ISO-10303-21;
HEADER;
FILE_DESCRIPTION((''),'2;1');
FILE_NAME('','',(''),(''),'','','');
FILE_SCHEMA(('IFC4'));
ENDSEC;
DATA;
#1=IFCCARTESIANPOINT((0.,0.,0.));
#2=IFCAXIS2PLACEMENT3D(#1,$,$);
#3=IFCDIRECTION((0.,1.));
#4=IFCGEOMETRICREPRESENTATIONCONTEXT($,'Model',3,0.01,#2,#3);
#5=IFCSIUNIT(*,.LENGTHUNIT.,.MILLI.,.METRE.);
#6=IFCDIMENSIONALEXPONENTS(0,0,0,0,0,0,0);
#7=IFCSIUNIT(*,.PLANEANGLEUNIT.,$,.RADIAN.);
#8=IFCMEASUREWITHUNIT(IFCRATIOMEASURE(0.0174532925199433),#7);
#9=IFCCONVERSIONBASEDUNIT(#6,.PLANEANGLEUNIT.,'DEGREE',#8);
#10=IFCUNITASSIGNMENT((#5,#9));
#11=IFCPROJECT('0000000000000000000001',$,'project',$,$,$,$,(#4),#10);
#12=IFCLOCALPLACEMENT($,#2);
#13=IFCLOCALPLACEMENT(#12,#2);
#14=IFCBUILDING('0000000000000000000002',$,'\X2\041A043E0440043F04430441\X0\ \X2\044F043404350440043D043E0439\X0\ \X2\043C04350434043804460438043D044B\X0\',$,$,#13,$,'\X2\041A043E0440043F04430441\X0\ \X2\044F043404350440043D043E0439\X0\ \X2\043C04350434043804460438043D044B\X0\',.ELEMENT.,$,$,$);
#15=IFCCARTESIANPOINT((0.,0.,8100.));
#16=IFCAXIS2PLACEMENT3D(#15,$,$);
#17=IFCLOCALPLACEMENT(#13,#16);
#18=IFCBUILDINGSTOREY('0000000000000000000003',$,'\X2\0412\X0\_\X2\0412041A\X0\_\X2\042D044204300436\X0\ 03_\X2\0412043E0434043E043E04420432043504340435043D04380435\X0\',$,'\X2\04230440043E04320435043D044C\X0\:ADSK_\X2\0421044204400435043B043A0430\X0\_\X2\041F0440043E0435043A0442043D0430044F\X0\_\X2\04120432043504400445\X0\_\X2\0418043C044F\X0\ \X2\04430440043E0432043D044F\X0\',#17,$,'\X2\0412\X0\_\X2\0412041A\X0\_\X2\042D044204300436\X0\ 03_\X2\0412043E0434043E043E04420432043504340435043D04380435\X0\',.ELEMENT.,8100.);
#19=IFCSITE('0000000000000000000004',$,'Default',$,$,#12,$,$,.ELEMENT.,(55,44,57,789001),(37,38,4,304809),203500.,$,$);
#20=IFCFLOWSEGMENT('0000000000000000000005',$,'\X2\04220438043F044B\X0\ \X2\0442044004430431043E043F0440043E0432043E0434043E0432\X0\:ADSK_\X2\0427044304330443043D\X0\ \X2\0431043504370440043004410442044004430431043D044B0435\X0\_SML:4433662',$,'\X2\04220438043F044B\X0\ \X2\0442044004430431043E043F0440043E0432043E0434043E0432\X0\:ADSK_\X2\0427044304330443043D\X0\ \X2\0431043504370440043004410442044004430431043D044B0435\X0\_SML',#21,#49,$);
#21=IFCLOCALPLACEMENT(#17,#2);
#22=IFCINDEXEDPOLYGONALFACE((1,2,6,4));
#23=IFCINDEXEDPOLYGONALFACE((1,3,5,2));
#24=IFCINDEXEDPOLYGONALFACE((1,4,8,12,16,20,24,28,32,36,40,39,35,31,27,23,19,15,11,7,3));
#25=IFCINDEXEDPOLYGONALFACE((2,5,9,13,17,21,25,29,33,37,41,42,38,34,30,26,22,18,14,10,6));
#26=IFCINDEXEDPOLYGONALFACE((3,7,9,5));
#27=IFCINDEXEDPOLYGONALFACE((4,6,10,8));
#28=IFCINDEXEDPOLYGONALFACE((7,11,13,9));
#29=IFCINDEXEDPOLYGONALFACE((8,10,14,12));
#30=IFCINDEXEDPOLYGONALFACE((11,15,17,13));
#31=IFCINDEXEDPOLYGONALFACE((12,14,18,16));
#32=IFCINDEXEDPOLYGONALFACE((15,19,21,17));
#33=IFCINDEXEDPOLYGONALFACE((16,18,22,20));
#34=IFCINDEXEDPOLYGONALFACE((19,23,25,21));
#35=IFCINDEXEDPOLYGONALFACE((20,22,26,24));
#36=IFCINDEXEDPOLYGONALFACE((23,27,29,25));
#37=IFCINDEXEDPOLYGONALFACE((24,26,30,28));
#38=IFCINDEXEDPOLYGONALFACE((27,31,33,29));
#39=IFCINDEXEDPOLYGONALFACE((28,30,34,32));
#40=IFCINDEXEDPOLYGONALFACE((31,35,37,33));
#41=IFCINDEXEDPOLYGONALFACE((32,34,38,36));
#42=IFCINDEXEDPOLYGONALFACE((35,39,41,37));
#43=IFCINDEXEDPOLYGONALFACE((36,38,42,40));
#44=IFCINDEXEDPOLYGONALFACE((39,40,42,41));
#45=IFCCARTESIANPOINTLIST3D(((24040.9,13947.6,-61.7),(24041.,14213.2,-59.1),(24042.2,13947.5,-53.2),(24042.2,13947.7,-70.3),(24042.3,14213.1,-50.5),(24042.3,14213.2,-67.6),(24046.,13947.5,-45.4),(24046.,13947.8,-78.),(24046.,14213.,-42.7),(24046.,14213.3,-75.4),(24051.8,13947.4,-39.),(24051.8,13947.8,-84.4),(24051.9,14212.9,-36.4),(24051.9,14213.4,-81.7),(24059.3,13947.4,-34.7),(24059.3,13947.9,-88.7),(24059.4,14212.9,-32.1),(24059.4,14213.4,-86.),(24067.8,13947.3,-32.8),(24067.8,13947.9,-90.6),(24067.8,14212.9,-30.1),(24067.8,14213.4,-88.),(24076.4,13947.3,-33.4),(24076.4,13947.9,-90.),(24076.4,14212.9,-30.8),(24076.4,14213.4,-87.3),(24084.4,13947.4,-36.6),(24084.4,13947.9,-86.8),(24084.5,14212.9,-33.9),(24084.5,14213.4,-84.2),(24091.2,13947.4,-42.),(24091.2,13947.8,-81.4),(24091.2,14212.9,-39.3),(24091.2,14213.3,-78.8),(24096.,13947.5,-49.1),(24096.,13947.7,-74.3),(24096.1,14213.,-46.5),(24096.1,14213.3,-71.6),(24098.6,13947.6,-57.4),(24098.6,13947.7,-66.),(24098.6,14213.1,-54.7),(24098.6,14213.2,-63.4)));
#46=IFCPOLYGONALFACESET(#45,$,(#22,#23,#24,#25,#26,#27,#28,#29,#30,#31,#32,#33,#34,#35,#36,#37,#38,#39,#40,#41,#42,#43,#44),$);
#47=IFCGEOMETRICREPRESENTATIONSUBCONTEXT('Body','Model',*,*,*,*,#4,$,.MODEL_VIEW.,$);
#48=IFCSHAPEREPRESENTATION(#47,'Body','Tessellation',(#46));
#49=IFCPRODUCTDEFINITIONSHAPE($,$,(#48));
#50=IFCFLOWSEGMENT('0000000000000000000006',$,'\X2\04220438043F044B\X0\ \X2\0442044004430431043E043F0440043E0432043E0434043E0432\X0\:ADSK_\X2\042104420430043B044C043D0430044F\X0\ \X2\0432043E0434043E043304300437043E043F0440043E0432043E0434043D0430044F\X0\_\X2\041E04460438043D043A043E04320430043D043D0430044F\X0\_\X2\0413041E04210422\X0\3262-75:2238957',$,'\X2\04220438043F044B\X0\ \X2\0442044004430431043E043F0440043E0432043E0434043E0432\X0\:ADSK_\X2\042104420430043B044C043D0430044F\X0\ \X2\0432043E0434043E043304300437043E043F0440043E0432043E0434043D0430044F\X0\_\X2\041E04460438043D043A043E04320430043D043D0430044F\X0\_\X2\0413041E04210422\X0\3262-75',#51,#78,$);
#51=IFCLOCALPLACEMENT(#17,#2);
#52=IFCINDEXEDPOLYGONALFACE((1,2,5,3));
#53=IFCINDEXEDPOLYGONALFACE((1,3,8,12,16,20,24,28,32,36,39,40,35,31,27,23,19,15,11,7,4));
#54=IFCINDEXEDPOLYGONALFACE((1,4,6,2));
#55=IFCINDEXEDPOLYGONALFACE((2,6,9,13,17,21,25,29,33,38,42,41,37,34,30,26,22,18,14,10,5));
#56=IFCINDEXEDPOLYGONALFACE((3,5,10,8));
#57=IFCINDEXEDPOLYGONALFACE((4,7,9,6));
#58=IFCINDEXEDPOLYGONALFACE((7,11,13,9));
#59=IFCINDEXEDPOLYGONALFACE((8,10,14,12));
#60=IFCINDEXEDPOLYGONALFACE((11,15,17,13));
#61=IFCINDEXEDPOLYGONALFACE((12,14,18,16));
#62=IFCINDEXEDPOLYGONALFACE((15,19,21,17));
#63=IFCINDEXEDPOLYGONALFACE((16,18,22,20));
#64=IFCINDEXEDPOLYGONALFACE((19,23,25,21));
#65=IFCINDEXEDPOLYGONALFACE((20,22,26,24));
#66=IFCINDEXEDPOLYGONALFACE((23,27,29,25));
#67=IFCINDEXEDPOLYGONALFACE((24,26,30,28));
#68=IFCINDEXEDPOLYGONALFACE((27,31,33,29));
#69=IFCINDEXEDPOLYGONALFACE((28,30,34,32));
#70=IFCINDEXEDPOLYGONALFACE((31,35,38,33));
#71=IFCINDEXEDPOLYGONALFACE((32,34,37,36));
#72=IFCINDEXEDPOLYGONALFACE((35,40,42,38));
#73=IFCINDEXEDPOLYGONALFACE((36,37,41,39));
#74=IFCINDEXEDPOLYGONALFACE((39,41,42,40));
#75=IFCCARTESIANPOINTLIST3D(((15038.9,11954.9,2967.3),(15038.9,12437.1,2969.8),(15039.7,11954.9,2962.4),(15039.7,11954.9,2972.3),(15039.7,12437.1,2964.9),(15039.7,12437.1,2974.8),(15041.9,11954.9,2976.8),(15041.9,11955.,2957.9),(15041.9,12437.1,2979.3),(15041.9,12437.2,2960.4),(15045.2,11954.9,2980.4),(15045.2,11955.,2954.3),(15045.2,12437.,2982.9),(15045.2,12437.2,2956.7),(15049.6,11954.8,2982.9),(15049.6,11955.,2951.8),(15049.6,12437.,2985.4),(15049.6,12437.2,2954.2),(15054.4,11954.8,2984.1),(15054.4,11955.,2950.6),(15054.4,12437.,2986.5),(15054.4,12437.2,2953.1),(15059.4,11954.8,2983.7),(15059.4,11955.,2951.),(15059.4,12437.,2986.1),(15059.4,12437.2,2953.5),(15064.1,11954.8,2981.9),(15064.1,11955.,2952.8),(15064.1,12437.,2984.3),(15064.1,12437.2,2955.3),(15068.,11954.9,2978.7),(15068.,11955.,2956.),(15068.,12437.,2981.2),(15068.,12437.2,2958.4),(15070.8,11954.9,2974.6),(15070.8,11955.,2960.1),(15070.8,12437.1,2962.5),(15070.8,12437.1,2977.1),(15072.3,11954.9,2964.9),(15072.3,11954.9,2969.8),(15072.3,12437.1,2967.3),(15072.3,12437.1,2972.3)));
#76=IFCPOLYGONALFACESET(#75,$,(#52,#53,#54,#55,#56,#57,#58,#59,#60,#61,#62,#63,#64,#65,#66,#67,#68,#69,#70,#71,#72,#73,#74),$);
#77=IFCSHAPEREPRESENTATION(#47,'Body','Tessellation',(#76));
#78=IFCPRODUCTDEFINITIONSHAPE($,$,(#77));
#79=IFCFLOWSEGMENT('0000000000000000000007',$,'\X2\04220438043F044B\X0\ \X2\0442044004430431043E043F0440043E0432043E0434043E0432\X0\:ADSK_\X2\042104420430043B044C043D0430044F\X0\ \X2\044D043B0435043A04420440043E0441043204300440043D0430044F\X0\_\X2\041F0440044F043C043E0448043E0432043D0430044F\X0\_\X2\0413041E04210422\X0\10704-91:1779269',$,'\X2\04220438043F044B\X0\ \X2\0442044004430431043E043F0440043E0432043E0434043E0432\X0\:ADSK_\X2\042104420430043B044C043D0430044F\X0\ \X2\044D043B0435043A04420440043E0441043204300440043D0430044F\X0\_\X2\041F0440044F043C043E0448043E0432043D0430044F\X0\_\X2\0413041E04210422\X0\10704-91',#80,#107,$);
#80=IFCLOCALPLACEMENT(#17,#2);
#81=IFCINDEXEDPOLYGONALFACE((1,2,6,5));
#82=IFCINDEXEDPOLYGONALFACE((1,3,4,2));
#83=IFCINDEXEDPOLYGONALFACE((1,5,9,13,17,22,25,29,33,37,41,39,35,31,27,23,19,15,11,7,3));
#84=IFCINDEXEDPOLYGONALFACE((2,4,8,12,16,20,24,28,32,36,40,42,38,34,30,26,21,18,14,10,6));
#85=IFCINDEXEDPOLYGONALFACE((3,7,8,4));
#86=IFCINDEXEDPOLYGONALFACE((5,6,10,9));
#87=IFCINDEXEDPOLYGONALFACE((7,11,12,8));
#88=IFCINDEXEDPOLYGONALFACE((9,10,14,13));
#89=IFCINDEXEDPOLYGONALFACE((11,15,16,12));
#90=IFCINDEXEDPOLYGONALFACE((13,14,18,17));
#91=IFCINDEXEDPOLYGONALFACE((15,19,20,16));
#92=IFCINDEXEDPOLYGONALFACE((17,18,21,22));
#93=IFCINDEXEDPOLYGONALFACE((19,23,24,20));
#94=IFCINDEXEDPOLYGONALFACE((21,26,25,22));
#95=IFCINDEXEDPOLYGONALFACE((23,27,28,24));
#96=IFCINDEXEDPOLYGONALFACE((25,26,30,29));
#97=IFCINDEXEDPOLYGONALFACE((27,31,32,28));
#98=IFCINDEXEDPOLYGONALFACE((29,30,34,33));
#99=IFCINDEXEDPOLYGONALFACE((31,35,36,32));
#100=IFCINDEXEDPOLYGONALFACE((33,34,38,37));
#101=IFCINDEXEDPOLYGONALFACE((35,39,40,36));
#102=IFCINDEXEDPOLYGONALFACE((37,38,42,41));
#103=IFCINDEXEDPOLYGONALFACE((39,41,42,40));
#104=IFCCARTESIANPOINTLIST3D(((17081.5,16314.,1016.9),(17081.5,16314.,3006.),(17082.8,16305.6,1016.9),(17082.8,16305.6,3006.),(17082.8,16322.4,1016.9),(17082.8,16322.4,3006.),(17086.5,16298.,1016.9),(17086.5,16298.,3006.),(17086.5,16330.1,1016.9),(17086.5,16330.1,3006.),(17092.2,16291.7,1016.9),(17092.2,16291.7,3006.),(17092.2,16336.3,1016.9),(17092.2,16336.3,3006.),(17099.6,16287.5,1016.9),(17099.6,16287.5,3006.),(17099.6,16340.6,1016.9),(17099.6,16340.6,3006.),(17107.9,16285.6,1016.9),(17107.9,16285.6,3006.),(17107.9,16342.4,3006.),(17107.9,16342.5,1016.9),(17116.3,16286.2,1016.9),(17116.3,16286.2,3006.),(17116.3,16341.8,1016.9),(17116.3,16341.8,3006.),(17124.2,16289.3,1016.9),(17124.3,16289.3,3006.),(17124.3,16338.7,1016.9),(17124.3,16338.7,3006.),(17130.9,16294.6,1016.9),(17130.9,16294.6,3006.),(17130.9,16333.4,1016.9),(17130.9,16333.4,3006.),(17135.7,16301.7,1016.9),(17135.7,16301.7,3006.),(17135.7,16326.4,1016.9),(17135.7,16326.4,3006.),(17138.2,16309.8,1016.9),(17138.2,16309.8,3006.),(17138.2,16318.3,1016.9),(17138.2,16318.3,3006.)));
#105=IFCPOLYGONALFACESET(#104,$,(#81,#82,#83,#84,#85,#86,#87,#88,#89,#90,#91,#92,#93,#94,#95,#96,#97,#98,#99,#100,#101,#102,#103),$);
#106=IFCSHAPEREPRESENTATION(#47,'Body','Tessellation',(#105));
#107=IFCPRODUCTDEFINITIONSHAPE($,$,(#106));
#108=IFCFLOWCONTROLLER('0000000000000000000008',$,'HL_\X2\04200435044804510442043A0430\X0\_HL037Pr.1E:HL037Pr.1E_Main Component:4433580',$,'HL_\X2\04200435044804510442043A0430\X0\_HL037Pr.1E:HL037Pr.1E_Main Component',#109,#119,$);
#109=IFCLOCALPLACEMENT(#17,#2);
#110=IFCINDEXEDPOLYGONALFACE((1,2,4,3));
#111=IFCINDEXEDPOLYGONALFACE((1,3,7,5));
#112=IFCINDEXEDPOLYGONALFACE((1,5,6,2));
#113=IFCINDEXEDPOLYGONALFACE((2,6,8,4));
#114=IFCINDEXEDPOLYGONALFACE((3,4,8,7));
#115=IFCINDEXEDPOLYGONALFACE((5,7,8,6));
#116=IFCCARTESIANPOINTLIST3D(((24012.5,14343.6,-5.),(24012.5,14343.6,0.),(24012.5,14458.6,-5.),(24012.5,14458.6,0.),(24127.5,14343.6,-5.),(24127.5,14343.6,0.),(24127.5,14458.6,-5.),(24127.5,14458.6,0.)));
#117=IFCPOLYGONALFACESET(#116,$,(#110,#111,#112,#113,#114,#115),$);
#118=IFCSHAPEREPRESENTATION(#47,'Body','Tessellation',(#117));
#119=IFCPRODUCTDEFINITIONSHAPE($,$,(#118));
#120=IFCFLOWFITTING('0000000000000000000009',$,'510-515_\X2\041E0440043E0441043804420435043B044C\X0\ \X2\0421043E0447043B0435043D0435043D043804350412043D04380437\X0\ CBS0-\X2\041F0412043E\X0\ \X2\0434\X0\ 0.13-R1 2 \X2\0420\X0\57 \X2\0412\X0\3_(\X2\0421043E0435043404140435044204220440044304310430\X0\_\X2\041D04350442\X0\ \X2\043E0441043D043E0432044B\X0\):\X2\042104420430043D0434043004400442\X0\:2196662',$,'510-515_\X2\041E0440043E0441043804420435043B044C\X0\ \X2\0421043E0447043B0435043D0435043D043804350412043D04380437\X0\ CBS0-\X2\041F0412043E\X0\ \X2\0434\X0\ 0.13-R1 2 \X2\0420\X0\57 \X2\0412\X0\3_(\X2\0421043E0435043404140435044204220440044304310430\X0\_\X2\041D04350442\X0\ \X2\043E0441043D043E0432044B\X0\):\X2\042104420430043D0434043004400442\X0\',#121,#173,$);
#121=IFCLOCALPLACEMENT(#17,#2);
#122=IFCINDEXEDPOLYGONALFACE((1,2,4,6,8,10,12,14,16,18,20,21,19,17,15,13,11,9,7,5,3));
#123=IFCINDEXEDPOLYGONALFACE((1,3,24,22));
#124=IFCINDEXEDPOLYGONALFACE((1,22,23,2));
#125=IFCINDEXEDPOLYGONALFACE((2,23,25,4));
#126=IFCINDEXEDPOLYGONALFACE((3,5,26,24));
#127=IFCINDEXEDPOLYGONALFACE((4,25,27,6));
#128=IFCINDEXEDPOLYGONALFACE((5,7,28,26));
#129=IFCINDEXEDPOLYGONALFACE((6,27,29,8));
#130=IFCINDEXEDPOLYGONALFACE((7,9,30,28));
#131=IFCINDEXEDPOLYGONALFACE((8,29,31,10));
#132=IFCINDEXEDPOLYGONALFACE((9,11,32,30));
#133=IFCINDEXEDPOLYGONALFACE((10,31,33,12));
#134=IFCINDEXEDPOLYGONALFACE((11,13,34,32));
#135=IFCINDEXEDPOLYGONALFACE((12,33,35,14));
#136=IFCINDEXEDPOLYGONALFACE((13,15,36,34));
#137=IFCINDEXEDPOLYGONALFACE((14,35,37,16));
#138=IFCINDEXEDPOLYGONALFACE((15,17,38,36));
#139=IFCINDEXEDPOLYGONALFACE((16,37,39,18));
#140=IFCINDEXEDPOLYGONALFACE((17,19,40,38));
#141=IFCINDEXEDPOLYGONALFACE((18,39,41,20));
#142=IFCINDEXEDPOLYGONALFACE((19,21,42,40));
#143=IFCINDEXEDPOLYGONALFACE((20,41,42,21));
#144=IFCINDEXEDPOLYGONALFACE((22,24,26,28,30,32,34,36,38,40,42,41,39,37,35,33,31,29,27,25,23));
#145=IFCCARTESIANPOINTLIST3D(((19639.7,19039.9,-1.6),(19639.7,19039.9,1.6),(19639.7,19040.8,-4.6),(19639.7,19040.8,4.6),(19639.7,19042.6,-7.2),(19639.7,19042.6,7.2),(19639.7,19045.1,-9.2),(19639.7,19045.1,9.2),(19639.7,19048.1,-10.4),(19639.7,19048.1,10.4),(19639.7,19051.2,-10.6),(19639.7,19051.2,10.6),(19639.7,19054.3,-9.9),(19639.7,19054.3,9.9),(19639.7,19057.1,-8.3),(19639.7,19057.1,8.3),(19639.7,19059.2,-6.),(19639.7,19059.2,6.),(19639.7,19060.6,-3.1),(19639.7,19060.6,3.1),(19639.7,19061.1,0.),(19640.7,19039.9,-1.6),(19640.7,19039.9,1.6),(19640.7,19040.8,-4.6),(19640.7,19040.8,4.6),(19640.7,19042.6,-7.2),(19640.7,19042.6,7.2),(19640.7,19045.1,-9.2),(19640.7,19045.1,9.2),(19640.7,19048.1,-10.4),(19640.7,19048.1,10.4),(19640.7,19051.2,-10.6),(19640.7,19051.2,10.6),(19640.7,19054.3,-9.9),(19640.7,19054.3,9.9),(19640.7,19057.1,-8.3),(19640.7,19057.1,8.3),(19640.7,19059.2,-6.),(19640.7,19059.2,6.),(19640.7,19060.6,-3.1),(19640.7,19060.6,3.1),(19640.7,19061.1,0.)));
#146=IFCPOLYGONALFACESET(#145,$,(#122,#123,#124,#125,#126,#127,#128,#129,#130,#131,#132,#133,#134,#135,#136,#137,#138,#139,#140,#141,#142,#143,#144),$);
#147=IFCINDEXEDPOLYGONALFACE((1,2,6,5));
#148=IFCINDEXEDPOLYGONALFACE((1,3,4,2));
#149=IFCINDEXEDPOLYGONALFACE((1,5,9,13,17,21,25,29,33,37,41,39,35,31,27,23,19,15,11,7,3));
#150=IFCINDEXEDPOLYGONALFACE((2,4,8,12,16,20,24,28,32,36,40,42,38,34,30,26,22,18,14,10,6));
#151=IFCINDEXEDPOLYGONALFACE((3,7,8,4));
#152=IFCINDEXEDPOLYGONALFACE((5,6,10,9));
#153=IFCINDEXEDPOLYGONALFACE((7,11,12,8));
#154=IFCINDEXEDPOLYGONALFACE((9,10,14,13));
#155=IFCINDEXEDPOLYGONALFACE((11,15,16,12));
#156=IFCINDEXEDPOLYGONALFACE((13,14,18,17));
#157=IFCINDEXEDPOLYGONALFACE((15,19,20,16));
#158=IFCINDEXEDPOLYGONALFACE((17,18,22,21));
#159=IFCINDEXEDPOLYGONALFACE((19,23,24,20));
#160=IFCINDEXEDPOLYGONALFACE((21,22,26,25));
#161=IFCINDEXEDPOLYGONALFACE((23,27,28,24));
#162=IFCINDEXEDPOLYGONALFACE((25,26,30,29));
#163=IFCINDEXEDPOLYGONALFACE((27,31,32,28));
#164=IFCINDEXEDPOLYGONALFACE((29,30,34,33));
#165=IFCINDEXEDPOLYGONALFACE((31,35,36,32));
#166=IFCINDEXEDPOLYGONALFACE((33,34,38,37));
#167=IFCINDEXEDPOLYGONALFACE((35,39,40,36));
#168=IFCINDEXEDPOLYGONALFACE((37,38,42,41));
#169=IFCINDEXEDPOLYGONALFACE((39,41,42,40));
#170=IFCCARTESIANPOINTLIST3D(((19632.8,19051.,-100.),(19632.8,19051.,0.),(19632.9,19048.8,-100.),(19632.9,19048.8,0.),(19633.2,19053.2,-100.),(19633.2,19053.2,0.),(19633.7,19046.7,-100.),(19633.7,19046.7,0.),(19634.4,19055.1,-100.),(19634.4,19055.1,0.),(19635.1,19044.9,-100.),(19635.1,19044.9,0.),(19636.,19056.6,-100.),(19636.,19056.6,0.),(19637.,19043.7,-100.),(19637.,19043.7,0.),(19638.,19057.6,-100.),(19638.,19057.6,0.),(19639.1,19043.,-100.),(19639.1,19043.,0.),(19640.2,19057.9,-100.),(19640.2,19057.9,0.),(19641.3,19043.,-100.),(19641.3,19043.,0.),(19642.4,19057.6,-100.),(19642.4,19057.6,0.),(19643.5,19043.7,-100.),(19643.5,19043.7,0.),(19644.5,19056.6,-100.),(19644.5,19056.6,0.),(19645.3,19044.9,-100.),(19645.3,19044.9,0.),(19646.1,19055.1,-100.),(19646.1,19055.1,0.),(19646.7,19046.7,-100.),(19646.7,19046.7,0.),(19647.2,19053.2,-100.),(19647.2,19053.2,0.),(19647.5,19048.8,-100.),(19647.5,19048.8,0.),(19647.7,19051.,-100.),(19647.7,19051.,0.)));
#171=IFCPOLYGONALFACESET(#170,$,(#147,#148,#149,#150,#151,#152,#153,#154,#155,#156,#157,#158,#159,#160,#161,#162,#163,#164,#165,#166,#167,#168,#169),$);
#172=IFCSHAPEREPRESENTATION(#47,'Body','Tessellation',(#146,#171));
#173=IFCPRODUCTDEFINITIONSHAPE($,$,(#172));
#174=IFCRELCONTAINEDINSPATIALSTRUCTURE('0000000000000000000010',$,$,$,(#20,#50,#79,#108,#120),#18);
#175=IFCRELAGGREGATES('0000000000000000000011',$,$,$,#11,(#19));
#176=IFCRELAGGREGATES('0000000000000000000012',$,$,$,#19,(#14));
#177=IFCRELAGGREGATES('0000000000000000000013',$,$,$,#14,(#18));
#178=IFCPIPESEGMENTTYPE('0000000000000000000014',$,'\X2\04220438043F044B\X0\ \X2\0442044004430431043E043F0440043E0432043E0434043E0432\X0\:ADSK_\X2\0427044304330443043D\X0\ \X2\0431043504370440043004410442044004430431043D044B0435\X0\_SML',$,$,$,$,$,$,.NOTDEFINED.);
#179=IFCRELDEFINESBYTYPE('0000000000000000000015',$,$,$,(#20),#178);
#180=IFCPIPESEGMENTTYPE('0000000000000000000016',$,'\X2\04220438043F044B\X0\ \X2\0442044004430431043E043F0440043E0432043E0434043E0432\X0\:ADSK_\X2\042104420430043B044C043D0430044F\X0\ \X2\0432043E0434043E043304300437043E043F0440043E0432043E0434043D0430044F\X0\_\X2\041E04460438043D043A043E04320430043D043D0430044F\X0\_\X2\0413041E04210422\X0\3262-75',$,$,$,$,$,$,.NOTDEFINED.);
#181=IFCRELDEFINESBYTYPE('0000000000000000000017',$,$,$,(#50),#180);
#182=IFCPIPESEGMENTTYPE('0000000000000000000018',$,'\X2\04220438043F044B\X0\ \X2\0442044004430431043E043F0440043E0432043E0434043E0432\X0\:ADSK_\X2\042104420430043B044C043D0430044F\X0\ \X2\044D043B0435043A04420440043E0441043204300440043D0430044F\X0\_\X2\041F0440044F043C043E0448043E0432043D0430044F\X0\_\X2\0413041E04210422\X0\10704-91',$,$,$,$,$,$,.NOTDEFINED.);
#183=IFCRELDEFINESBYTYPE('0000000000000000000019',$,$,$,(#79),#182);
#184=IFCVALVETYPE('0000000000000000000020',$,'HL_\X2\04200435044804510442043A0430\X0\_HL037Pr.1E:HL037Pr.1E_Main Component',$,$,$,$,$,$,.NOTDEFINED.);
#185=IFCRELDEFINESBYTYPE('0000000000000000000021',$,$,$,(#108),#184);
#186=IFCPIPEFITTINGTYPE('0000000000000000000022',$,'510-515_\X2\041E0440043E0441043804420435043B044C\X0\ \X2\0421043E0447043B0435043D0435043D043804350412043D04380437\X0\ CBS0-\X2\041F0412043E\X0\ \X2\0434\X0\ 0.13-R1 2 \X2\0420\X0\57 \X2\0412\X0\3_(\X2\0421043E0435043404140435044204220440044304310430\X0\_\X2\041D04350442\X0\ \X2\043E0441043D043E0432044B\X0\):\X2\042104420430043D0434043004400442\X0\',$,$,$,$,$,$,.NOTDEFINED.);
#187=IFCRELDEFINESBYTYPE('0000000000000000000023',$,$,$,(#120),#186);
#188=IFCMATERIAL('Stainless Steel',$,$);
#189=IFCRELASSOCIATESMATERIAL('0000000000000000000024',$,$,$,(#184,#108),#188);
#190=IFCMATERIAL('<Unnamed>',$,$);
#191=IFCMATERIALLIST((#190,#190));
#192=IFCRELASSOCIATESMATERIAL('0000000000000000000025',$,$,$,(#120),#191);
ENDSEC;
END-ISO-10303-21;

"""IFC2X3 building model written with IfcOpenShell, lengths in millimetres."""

from ifc_helpers import new_model, entity, si_unit, converted_unit, direction, frame, origin, origin_2d_with_axis, place, context, subcontext, project, spatial, rectangle, circle, extrude, source, transform, mapped, material, material_list, type_object, type_shapes, element, save


model = new_model("IFC2X3")

# Units and contexts
model_context = context("Model", 3, precision=0.01, world=origin(), true_north=direction((0.0, 1.0)))
body_context = subcontext(model_context, "Body", "Model", "MODEL_VIEW")
ifc_project = project(units=[si_unit("LENGTHUNIT", "METRE", prefix="MILLI"), converted_unit("PLANEANGLEUNIT", "DEGREE", entity("IfcRatioMeasure", 0.0174532925199433), si_unit("PLANEANGLEUNIT", "RADIAN"), dimensions=[0, 0, 0, 0, 0, 0, 0])], contexts=[model_context])

# Site, building, storey
site_placement = place(None, origin())
site = spatial("IfcSite", under=ifc_project, at=site_placement, Name="Default", CompositionType="ELEMENT", RefLatitude=(55, 44, 57, 789001), RefLongitude=(37, 38, 4, 304809), RefElevation=203500.0)
building_placement = place(site_placement, origin())
building = spatial("IfcBuilding", under=site, at=building_placement, Name="Корпус ядерной медицины", LongName="Корпус ядерной медицины", CompositionType="ELEMENT")
storey_placement = place(building_placement, frame((0.0, 0.0, 8100.0)))
storey = spatial("IfcBuildingStorey", under=building, at=storey_placement, Name="В_ВК_Этаж 03_Водоотведение", ObjectType="Уровень:ADSK_Стрелка_Проектная_Вверх_Имя уровня", LongName="В_ВК_Этаж 03_Водоотведение", CompositionType="ELEMENT", Elevation=8100.0)

# Flow segments
pipe_segment_type_1 = type_object("IfcPipeSegmentType", Name="Типы трубопроводов:ADSK_Чугун безраструбные_SML", PredefinedType="NOTDEFINED")
flow_segment_1_placement = place(storey_placement, frame((24039.3, 13945.7, -92.3)))
element("IfcFlowSegment", 1, at=flow_segment_1_placement, inside=storey, type_object=pipe_segment_type_1, Name="Типы трубопроводов:ADSK_Чугун безраструбные_SML:4433662", ObjectType="Типы трубопроводов:ADSK_Чугун безраструбные_SML", context=body_context, shape_type="SweptSolid", body=[
    extrude(circle(Radius=29.0, at=origin_2d_with_axis()), frame((30.6, 1.9, 30.6), z_axis=(0.000159, 0.99995, 0.009999), x_axis=(-1.0, 0.000159, 0.0)), (0.0, 0.0, 1.0), 265.5),
])
pipe_segment_type_2 = type_object("IfcPipeSegmentType", Name="Типы трубопроводов:ADSK_Стальная водогазопроводная_Оцинкованная_ГОСТ3262-75", PredefinedType="NOTDEFINED")
flow_segment_2_placement = place(storey_placement, frame((15037.3, 11954.8, 2949.0)))
element("IfcFlowSegment", 2, at=flow_segment_2_placement, inside=storey, type_object=pipe_segment_type_2, Name="Типы трубопроводов:ADSK_Стальная водогазопроводная_Оцинкованная_ГОСТ3262-75:2238957", ObjectType="Типы трубопроводов:ADSK_Стальная водогазопроводная_Оцинкованная_ГОСТ3262-75", context=body_context, shape_type="SweptSolid", body=[
    extrude(circle(Radius=16.8, at=origin_2d_with_axis()), frame((18.4, 0.1, 18.4), z_axis=(0.0, 0.999987, 0.005114), x_axis=(-1.0, 0.0, 0.0)), (0.0, 0.0, 1.0), 482.2),
])
pipe_segment_type_3 = type_object("IfcPipeSegmentType", Name="Типы трубопроводов:ADSK_Стальная электросварная_Прямошовная_ГОСТ10704-91", PredefinedType="NOTDEFINED")
flow_segment_3_placement = place(storey_placement, frame((17079.9, 16283.9, 1016.9)))
element("IfcFlowSegment", 3, at=flow_segment_3_placement, inside=storey, type_object=pipe_segment_type_3, Name="Типы трубопроводов:ADSK_Стальная электросварная_Прямошовная_ГОСТ10704-91:1779269", ObjectType="Типы трубопроводов:ADSK_Стальная электросварная_Прямошовная_ГОСТ10704-91", context=body_context, shape_type="SweptSolid", body=[
    extrude(circle(Radius=28.5, at=origin_2d_with_axis()), frame((30.1, 30.1, 0.0), z_axis=(0.000001, 0.0, 1.0), x_axis=(-1.0, 0.0, 0.000001)), (0.0, 0.0, 1.0), 1989.1),
])

# Flow controller
ifc_material_1 = material(Name="Stainless Steel")
valve_type = type_object("IfcValveType", Name="HL_Решётка_HL037Pr.1E:HL037Pr.1E_Main Component", PredefinedType="NOTDEFINED", material=ifc_material_1)
shared_shape_1 = source(origin(), body_context, "Body", "SweptSolid", [
    extrude(rectangle(XDim=115.0, YDim=115.0, at=origin_2d_with_axis()), frame((0.0, 0.0, -5.0), z_axis=(0.0, 0.0, 1.0), x_axis=(0.0, -1.0, 0.0)), (0.0, 0.0, 1.0), 5.0),
])
type_shapes(valve_type, [shared_shape_1])
flow_controller_placement = place(storey_placement, frame((24070.0, 14401.1, 0.0), z_axis=(0.0, 0.0, 1.0), x_axis=(0.0, -1.0, 0.0)))
element("IfcFlowController", 4, at=flow_controller_placement, inside=storey, type_object=valve_type, material=ifc_material_1, Name="HL_Решётка_HL037Pr.1E:HL037Pr.1E_Main Component:4433580", ObjectType="HL_Решётка_HL037Pr.1E:HL037Pr.1E_Main Component", context=body_context, shape_type="MappedRepresentation", body=[
    mapped(shared_shape_1, transform((0.0, 0.0, 0.0), scale=1.0)),
])

# Flow fitting
ifc_material_2 = material(Name="<Unnamed>")
ifc_material_list = material_list([ifc_material_2, ifc_material_2])
pipe_fitting_type_1 = type_object("IfcPipeFittingType", Name="510-515_Ороситель СочленениеВниз CBS0-ПВо д 0.13-R1 2 Р57 В3_(СоедДетТруба_Нет основы):Стандарт", PredefinedType="NOTDEFINED")
shared_shape_2 = source(origin(), body_context, "Body", "SweptSolid", [
    extrude(circle(Radius=10.7, at=origin_2d_with_axis()), frame((-0.5, 0.0, 0.0), z_axis=(1.0, 0.0, 0.0), x_axis=(0.0, 1.0, 0.0)), (0.0, 0.0, 1.0), 1.0),
    extrude(circle(Radius=7.5, at=origin_2d_with_axis()), frame((0.0, 0.0, -100.0), z_axis=(0.0, 0.0, 1.0), x_axis=(0.0, 1.0, 0.0)), (0.0, 0.0, 1.0), 100.0),
])
type_shapes(pipe_fitting_type_1, [shared_shape_2])
flow_fitting_placement = place(storey_placement, frame((19640.2, 19050.4, 0.0)))
element("IfcFlowFitting", 5, at=flow_fitting_placement, inside=storey, type_object=pipe_fitting_type_1, material=ifc_material_list, Name="510-515_Ороситель СочленениеВниз CBS0-ПВо д 0.13-R1 2 Р57 В3_(СоедДетТруба_Нет основы):Стандарт:2196662", ObjectType="510-515_Ороситель СочленениеВниз CBS0-ПВо д 0.13-R1 2 Р57 В3_(СоедДетТруба_Нет основы):Стандарт", context=body_context, shape_type="MappedRepresentation", body=[
    mapped(shared_shape_2, transform((0.0, 0.0, 0.0), scale=1.0)),
])

save(model, "model.ifc")
